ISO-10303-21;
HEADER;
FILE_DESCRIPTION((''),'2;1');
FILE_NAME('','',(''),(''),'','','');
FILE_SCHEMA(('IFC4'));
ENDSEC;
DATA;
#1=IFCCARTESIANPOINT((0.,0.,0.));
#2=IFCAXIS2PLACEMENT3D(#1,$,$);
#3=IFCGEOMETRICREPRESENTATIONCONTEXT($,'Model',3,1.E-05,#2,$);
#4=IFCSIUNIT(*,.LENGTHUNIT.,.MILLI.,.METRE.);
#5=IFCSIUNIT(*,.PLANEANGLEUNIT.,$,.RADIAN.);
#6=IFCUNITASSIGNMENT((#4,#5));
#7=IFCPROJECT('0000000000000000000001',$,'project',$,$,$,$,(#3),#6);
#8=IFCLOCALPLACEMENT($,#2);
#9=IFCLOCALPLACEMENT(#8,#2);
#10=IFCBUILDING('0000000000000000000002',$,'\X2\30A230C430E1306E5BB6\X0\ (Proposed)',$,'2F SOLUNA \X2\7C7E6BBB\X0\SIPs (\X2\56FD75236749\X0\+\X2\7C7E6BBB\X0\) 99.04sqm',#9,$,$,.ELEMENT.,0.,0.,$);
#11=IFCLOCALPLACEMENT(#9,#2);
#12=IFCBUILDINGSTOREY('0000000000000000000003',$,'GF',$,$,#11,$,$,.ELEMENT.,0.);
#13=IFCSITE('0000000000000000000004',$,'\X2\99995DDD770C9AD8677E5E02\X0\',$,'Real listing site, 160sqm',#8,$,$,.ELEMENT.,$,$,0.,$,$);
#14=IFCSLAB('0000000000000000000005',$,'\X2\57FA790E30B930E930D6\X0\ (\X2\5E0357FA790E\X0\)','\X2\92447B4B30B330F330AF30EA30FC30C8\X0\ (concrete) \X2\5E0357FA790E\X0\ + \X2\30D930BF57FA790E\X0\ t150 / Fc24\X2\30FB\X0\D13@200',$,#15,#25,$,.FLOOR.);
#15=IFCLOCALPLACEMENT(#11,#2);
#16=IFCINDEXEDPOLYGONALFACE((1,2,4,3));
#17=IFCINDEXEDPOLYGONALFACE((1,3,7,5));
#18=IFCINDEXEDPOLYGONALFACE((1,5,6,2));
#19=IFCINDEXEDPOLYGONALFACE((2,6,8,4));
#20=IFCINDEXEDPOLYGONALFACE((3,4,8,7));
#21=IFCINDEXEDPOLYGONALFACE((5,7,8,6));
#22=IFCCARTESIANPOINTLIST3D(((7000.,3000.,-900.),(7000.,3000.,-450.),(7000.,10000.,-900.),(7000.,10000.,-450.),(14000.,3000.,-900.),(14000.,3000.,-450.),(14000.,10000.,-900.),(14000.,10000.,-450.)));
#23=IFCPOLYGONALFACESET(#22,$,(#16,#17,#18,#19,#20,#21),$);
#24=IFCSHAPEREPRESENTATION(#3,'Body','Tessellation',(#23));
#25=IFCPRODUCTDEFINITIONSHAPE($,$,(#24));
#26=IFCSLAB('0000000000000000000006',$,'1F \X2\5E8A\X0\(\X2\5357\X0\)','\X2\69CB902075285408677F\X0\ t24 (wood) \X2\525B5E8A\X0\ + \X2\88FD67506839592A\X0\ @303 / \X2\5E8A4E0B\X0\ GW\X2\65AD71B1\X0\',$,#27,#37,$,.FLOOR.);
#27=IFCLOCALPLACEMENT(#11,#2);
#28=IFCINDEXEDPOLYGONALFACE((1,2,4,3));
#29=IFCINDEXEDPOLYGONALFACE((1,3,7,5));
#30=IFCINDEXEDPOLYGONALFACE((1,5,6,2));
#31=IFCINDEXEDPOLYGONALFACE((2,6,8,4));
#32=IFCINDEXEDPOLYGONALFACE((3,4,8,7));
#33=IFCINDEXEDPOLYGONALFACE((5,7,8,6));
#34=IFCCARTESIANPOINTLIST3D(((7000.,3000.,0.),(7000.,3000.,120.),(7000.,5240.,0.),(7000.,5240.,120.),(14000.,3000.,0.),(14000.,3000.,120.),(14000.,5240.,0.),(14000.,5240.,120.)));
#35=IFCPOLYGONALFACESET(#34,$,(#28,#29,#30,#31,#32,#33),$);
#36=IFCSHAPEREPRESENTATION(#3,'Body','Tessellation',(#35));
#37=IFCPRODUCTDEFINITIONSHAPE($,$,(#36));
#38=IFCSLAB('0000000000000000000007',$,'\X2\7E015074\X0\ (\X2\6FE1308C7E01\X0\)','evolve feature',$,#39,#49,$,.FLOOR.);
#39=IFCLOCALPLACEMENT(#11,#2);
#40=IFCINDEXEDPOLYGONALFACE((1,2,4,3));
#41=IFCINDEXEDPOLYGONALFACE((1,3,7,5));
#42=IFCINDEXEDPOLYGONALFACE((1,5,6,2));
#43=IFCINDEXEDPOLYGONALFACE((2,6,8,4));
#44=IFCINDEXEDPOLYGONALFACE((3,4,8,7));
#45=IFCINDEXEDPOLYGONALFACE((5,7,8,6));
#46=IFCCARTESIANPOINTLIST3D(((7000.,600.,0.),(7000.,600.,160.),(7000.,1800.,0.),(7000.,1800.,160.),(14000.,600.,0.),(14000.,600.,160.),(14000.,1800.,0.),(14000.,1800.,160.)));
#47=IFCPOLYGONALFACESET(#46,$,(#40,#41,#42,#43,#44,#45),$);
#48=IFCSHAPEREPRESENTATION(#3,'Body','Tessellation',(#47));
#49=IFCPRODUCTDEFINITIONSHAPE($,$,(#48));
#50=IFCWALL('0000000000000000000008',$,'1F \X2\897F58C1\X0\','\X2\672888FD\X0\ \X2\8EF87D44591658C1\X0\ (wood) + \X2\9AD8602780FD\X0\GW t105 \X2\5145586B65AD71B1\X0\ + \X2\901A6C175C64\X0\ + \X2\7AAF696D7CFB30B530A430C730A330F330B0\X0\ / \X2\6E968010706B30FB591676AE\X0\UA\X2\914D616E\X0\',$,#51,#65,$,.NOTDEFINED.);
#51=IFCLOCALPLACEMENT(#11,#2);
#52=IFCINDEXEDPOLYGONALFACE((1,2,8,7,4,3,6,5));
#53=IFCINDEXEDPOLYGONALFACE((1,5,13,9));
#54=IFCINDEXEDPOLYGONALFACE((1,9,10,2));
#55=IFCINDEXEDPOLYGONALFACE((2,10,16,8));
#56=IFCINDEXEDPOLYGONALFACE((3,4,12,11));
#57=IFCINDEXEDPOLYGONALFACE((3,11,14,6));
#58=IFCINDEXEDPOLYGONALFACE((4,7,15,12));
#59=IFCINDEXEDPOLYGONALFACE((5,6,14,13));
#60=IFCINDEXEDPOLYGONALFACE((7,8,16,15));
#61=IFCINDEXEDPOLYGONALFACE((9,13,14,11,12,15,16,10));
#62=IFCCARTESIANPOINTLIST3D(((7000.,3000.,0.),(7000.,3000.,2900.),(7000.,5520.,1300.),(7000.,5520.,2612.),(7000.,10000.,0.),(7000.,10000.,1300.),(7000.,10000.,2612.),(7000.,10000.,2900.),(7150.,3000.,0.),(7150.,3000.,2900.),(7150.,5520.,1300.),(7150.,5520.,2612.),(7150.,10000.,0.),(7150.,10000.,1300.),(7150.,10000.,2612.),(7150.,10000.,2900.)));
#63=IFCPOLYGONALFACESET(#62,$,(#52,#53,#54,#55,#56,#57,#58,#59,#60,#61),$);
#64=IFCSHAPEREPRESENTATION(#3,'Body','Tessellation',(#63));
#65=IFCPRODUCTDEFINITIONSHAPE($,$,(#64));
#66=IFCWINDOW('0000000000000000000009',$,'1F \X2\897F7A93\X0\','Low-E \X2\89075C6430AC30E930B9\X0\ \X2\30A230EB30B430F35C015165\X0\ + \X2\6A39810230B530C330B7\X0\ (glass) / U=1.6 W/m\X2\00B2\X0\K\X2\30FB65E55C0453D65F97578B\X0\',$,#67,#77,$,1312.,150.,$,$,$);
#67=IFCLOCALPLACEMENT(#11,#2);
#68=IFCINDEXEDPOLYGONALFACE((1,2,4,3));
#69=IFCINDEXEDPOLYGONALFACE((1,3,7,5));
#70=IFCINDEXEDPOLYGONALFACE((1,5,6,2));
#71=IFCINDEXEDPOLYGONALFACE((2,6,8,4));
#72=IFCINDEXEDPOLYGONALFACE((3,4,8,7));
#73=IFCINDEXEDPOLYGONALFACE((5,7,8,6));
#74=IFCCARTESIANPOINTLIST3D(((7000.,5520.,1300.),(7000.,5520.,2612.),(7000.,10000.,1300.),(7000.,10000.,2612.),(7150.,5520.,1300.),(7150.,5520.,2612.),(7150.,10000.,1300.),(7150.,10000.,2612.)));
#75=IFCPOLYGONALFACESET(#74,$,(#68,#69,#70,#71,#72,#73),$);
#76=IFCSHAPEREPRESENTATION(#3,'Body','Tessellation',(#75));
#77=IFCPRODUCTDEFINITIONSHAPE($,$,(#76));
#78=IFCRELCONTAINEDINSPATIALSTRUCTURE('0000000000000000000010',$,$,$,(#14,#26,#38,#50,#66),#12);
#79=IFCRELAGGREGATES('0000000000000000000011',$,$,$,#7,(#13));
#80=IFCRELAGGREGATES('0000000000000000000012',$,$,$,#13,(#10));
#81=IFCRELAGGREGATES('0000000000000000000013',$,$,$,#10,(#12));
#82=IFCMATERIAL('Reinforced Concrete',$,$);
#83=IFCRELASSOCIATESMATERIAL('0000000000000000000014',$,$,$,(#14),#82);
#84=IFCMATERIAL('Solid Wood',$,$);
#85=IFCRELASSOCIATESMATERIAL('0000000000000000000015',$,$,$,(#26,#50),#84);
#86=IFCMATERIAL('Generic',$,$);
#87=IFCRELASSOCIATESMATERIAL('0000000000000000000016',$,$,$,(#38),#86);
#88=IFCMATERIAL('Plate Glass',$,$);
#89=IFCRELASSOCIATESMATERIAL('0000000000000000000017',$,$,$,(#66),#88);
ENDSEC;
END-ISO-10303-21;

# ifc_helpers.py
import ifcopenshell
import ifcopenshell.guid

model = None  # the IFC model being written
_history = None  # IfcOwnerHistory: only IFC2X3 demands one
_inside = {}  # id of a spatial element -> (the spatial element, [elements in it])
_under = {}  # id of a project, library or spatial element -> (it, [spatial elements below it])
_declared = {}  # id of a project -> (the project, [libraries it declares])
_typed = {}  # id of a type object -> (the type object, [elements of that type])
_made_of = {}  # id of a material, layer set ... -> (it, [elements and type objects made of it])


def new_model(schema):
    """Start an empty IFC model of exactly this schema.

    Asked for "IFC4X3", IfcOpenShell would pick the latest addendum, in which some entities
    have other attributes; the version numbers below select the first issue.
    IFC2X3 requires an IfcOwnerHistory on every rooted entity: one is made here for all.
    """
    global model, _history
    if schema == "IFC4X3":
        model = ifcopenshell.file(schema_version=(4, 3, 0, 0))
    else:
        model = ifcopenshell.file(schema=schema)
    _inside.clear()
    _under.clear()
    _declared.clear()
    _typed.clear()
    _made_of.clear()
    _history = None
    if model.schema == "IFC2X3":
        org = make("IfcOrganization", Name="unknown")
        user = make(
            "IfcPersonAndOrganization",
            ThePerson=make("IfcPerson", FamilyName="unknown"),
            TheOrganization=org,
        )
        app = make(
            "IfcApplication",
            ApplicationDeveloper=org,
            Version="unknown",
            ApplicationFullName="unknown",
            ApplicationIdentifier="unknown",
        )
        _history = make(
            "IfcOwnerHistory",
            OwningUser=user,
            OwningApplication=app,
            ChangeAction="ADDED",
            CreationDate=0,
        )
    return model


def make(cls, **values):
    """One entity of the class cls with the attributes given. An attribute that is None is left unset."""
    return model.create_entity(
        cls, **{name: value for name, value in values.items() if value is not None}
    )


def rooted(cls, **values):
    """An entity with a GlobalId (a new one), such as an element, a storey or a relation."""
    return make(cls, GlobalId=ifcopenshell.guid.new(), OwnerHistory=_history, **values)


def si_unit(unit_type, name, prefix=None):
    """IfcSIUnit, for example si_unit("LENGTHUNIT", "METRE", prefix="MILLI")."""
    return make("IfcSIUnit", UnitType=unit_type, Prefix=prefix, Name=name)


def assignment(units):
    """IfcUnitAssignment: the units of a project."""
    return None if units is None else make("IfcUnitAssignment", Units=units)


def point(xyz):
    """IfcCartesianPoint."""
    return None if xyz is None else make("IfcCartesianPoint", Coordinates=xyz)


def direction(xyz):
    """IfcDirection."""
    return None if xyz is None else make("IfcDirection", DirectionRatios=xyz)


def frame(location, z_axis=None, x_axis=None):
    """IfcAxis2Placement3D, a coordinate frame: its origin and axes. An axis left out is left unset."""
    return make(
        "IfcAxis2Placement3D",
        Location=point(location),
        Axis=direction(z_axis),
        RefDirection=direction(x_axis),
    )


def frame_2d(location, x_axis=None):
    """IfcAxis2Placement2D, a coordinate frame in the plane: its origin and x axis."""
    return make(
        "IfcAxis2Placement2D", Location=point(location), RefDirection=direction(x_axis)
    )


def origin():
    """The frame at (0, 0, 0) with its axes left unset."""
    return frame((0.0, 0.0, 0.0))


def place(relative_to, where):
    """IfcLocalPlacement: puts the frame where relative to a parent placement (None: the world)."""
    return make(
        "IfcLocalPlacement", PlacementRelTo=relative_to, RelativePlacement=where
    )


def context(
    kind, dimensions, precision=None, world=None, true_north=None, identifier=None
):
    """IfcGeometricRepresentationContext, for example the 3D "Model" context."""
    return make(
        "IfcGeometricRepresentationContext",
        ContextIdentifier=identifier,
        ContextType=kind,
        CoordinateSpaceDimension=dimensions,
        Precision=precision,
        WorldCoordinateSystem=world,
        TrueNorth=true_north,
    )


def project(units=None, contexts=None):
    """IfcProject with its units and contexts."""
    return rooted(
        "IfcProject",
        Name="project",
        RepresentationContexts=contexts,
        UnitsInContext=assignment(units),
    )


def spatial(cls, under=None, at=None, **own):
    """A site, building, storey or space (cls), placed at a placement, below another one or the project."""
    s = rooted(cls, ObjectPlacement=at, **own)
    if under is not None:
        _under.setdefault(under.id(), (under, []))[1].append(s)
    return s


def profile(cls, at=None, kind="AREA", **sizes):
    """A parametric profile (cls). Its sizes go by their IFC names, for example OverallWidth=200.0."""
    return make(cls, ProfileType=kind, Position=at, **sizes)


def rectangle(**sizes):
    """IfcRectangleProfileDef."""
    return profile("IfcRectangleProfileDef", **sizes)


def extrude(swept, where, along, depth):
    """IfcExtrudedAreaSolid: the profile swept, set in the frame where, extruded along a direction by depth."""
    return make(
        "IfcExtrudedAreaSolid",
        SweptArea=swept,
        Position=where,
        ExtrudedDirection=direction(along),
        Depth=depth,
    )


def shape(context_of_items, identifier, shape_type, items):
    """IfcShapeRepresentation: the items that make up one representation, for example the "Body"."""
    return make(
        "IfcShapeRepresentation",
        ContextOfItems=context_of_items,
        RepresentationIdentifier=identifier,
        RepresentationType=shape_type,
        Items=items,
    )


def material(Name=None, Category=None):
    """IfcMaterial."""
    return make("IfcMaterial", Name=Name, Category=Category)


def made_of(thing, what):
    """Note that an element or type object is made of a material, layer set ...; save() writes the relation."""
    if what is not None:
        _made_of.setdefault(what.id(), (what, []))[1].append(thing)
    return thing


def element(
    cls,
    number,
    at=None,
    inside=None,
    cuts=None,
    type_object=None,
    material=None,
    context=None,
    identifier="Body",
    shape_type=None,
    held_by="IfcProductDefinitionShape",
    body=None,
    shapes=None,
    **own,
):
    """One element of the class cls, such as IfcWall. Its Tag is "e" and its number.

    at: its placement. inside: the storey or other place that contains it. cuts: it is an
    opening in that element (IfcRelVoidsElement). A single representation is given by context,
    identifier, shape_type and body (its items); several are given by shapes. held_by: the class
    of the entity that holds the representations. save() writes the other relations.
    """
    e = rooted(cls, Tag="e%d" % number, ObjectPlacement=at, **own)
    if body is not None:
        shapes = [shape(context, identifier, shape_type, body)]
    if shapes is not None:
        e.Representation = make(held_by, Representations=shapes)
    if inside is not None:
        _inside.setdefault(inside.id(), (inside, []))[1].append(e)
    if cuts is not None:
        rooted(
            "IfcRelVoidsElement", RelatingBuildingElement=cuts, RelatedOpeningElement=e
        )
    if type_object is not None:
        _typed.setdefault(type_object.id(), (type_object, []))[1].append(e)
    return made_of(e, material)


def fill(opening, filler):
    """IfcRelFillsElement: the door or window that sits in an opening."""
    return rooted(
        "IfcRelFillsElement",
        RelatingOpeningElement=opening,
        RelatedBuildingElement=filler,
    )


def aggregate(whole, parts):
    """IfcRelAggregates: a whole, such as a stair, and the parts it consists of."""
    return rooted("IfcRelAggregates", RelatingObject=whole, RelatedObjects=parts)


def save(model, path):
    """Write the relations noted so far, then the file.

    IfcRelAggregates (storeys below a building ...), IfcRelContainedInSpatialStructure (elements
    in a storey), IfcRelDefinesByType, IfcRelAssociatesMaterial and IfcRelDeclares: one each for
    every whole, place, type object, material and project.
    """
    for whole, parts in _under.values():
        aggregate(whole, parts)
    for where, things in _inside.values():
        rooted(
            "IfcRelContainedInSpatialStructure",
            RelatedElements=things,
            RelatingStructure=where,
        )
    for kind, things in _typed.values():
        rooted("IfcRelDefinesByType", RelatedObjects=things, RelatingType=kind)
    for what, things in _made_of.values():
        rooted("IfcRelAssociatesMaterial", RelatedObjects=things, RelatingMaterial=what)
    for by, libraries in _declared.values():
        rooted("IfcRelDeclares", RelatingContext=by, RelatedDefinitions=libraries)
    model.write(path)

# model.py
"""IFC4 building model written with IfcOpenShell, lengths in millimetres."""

from ifc_helpers import new_model, si_unit, frame, frame_2d, origin, place, context, project, spatial, rectangle, extrude, material, element, fill, save


model = new_model("IFC4")

# Units and contexts
model_context = context("Model", 3, precision=1e-05, world=origin())
ifc_project = project(units=[si_unit("LENGTHUNIT", "METRE", prefix="MILLI"), si_unit("PLANEANGLEUNIT", "RADIAN")], contexts=[model_context])

# Site, building, storey
site_placement = place(None, origin())
site = spatial("IfcSite", under=ifc_project, at=site_placement, Name="香川県高松市", ObjectType="Real listing site, 160sqm", CompositionType="ELEMENT", RefElevation=0.0)
building_placement = place(site_placement, origin())
building = spatial("IfcBuilding", under=site, at=building_placement, Name="アツメの家 (Proposed)", ObjectType="2F SOLUNA 籾殻SIPs (国産杉+籾殻) 99.04sqm", CompositionType="ELEMENT", ElevationOfRefHeight=0.0, ElevationOfTerrain=0.0)
storey_placement = place(building_placement, origin())
storey = spatial("IfcBuildingStorey", under=building, at=storey_placement, Name="GF", CompositionType="ELEMENT", Elevation=0.0)

# Slabs
ifc_material_1 = material(Name="Reinforced Concrete")
slab_1_placement = place(storey_placement, frame((3500.0, 1500.0, -450.0)))
element("IfcSlab", 1, at=slab_1_placement, inside=storey, material=ifc_material_1, Name="基礎スラブ (布基礎)", Description="鉄筋コンクリート (concrete) 布基礎 + ベタ基礎 t150 / Fc24・D13@200", PredefinedType="FLOOR", context=model_context, shape_type="SweptSolid", body=[
    extrude(rectangle(XDim=7000.0, YDim=7000.0, at=frame_2d((3500.0, 3500.0))), frame((3500.0, 1500.0, -450.0)), (0.0, 0.0, 1.0), 450.0),
])
ifc_material_2 = material(Name="Solid Wood")
slab_2_placement = place(storey_placement, frame((3500.0, 1500.0, 0.0)))
element("IfcSlab", 2, at=slab_2_placement, inside=storey, material=ifc_material_2, Name="1F 床(南)", Description="構造用合板 t24 (wood) 剛床 + 製材根太 @303 / 床下 GW断熱", PredefinedType="FLOOR", context=model_context, shape_type="SweptSolid", body=[
    extrude(rectangle(XDim=7000.0, YDim=2240.0, at=frame_2d((3500.0, 1120.0))), frame((3500.0, 1500.0, 0.0)), (0.0, 0.0, 1.0), 120.0),
])
ifc_material_3 = material(Name="Generic")
slab_3_placement = place(storey_placement, frame((3500.0, 300.0, 0.0)))
element("IfcSlab", 3, at=slab_3_placement, inside=storey, material=ifc_material_3, Name="縁側 (濡れ縁)", Description="evolve feature", PredefinedType="FLOOR", context=model_context, shape_type="SweptSolid", body=[
    extrude(rectangle(XDim=7000.0, YDim=1200.0, at=frame_2d((3500.0, 600.0))), frame((3500.0, 300.0, 0.0)), (0.0, 0.0, 1.0), 160.0),
])

# Shared definitions
ifc_material_4 = material(Name="Plate Glass")

# Wall, opening, window
wall_1_placement = place(storey_placement, frame((3500.0, 1500.0, 0.0)))
wall_1 = element("IfcWall", 4, at=wall_1_placement, inside=storey, material=ifc_material_2, Name="1F 西壁", Description="木製 軸組外壁 (wood) + 高性能GW t105 充填断熱 + 通気層 + 窯業系サイディング / 準耐火・外皮UA配慮", PredefinedType="NOTDEFINED", context=model_context, shape_type="SweptSolid", body=[
    extrude(rectangle(XDim=150.0, YDim=7000.0, at=frame_2d((75.0, 3500.0))), frame((3500.0, 1500.0, 0.0)), (0.0, 0.0, 1.0), 2900.0),
])
opening_1_placement = place(storey_placement, frame((3500.0, 2760.0, 650.0)))
opening_1 = element("IfcOpeningElement", 5, at=opening_1_placement, cuts=wall_1, PredefinedType="NOTDEFINED", context=model_context, shape_type="SweptSolid", body=[
    extrude(rectangle(XDim=150.0, YDim=4480.0, at=frame_2d((75.0, 2240.0))), frame((3500.0, 2760.0, 650.0)), (0.0, 0.0, 1.0), 1312.0),
])
window_1_placement = place(storey_placement, frame((3500.0, 2760.0, 650.0)))
window_1 = element("IfcWindow", 6, at=window_1_placement, inside=storey, material=ifc_material_4, Name="1F 西窓", Description="Low-E 複層ガラス アルゴン封入 + 樹脂サッシ (glass) / U=1.6 W/m²K・日射取得型", OverallHeight=1312.0, OverallWidth=150.0, context=model_context, shape_type="SweptSolid", body=[
    extrude(rectangle(XDim=150.0, YDim=4480.0, at=frame_2d((75.0, 2240.0))), frame((3500.0, 2760.0, 650.0)), (0.0, 0.0, 1.0), 1312.0),
])
fill(opening_1, window_1)

save(model, "model.ifc")
